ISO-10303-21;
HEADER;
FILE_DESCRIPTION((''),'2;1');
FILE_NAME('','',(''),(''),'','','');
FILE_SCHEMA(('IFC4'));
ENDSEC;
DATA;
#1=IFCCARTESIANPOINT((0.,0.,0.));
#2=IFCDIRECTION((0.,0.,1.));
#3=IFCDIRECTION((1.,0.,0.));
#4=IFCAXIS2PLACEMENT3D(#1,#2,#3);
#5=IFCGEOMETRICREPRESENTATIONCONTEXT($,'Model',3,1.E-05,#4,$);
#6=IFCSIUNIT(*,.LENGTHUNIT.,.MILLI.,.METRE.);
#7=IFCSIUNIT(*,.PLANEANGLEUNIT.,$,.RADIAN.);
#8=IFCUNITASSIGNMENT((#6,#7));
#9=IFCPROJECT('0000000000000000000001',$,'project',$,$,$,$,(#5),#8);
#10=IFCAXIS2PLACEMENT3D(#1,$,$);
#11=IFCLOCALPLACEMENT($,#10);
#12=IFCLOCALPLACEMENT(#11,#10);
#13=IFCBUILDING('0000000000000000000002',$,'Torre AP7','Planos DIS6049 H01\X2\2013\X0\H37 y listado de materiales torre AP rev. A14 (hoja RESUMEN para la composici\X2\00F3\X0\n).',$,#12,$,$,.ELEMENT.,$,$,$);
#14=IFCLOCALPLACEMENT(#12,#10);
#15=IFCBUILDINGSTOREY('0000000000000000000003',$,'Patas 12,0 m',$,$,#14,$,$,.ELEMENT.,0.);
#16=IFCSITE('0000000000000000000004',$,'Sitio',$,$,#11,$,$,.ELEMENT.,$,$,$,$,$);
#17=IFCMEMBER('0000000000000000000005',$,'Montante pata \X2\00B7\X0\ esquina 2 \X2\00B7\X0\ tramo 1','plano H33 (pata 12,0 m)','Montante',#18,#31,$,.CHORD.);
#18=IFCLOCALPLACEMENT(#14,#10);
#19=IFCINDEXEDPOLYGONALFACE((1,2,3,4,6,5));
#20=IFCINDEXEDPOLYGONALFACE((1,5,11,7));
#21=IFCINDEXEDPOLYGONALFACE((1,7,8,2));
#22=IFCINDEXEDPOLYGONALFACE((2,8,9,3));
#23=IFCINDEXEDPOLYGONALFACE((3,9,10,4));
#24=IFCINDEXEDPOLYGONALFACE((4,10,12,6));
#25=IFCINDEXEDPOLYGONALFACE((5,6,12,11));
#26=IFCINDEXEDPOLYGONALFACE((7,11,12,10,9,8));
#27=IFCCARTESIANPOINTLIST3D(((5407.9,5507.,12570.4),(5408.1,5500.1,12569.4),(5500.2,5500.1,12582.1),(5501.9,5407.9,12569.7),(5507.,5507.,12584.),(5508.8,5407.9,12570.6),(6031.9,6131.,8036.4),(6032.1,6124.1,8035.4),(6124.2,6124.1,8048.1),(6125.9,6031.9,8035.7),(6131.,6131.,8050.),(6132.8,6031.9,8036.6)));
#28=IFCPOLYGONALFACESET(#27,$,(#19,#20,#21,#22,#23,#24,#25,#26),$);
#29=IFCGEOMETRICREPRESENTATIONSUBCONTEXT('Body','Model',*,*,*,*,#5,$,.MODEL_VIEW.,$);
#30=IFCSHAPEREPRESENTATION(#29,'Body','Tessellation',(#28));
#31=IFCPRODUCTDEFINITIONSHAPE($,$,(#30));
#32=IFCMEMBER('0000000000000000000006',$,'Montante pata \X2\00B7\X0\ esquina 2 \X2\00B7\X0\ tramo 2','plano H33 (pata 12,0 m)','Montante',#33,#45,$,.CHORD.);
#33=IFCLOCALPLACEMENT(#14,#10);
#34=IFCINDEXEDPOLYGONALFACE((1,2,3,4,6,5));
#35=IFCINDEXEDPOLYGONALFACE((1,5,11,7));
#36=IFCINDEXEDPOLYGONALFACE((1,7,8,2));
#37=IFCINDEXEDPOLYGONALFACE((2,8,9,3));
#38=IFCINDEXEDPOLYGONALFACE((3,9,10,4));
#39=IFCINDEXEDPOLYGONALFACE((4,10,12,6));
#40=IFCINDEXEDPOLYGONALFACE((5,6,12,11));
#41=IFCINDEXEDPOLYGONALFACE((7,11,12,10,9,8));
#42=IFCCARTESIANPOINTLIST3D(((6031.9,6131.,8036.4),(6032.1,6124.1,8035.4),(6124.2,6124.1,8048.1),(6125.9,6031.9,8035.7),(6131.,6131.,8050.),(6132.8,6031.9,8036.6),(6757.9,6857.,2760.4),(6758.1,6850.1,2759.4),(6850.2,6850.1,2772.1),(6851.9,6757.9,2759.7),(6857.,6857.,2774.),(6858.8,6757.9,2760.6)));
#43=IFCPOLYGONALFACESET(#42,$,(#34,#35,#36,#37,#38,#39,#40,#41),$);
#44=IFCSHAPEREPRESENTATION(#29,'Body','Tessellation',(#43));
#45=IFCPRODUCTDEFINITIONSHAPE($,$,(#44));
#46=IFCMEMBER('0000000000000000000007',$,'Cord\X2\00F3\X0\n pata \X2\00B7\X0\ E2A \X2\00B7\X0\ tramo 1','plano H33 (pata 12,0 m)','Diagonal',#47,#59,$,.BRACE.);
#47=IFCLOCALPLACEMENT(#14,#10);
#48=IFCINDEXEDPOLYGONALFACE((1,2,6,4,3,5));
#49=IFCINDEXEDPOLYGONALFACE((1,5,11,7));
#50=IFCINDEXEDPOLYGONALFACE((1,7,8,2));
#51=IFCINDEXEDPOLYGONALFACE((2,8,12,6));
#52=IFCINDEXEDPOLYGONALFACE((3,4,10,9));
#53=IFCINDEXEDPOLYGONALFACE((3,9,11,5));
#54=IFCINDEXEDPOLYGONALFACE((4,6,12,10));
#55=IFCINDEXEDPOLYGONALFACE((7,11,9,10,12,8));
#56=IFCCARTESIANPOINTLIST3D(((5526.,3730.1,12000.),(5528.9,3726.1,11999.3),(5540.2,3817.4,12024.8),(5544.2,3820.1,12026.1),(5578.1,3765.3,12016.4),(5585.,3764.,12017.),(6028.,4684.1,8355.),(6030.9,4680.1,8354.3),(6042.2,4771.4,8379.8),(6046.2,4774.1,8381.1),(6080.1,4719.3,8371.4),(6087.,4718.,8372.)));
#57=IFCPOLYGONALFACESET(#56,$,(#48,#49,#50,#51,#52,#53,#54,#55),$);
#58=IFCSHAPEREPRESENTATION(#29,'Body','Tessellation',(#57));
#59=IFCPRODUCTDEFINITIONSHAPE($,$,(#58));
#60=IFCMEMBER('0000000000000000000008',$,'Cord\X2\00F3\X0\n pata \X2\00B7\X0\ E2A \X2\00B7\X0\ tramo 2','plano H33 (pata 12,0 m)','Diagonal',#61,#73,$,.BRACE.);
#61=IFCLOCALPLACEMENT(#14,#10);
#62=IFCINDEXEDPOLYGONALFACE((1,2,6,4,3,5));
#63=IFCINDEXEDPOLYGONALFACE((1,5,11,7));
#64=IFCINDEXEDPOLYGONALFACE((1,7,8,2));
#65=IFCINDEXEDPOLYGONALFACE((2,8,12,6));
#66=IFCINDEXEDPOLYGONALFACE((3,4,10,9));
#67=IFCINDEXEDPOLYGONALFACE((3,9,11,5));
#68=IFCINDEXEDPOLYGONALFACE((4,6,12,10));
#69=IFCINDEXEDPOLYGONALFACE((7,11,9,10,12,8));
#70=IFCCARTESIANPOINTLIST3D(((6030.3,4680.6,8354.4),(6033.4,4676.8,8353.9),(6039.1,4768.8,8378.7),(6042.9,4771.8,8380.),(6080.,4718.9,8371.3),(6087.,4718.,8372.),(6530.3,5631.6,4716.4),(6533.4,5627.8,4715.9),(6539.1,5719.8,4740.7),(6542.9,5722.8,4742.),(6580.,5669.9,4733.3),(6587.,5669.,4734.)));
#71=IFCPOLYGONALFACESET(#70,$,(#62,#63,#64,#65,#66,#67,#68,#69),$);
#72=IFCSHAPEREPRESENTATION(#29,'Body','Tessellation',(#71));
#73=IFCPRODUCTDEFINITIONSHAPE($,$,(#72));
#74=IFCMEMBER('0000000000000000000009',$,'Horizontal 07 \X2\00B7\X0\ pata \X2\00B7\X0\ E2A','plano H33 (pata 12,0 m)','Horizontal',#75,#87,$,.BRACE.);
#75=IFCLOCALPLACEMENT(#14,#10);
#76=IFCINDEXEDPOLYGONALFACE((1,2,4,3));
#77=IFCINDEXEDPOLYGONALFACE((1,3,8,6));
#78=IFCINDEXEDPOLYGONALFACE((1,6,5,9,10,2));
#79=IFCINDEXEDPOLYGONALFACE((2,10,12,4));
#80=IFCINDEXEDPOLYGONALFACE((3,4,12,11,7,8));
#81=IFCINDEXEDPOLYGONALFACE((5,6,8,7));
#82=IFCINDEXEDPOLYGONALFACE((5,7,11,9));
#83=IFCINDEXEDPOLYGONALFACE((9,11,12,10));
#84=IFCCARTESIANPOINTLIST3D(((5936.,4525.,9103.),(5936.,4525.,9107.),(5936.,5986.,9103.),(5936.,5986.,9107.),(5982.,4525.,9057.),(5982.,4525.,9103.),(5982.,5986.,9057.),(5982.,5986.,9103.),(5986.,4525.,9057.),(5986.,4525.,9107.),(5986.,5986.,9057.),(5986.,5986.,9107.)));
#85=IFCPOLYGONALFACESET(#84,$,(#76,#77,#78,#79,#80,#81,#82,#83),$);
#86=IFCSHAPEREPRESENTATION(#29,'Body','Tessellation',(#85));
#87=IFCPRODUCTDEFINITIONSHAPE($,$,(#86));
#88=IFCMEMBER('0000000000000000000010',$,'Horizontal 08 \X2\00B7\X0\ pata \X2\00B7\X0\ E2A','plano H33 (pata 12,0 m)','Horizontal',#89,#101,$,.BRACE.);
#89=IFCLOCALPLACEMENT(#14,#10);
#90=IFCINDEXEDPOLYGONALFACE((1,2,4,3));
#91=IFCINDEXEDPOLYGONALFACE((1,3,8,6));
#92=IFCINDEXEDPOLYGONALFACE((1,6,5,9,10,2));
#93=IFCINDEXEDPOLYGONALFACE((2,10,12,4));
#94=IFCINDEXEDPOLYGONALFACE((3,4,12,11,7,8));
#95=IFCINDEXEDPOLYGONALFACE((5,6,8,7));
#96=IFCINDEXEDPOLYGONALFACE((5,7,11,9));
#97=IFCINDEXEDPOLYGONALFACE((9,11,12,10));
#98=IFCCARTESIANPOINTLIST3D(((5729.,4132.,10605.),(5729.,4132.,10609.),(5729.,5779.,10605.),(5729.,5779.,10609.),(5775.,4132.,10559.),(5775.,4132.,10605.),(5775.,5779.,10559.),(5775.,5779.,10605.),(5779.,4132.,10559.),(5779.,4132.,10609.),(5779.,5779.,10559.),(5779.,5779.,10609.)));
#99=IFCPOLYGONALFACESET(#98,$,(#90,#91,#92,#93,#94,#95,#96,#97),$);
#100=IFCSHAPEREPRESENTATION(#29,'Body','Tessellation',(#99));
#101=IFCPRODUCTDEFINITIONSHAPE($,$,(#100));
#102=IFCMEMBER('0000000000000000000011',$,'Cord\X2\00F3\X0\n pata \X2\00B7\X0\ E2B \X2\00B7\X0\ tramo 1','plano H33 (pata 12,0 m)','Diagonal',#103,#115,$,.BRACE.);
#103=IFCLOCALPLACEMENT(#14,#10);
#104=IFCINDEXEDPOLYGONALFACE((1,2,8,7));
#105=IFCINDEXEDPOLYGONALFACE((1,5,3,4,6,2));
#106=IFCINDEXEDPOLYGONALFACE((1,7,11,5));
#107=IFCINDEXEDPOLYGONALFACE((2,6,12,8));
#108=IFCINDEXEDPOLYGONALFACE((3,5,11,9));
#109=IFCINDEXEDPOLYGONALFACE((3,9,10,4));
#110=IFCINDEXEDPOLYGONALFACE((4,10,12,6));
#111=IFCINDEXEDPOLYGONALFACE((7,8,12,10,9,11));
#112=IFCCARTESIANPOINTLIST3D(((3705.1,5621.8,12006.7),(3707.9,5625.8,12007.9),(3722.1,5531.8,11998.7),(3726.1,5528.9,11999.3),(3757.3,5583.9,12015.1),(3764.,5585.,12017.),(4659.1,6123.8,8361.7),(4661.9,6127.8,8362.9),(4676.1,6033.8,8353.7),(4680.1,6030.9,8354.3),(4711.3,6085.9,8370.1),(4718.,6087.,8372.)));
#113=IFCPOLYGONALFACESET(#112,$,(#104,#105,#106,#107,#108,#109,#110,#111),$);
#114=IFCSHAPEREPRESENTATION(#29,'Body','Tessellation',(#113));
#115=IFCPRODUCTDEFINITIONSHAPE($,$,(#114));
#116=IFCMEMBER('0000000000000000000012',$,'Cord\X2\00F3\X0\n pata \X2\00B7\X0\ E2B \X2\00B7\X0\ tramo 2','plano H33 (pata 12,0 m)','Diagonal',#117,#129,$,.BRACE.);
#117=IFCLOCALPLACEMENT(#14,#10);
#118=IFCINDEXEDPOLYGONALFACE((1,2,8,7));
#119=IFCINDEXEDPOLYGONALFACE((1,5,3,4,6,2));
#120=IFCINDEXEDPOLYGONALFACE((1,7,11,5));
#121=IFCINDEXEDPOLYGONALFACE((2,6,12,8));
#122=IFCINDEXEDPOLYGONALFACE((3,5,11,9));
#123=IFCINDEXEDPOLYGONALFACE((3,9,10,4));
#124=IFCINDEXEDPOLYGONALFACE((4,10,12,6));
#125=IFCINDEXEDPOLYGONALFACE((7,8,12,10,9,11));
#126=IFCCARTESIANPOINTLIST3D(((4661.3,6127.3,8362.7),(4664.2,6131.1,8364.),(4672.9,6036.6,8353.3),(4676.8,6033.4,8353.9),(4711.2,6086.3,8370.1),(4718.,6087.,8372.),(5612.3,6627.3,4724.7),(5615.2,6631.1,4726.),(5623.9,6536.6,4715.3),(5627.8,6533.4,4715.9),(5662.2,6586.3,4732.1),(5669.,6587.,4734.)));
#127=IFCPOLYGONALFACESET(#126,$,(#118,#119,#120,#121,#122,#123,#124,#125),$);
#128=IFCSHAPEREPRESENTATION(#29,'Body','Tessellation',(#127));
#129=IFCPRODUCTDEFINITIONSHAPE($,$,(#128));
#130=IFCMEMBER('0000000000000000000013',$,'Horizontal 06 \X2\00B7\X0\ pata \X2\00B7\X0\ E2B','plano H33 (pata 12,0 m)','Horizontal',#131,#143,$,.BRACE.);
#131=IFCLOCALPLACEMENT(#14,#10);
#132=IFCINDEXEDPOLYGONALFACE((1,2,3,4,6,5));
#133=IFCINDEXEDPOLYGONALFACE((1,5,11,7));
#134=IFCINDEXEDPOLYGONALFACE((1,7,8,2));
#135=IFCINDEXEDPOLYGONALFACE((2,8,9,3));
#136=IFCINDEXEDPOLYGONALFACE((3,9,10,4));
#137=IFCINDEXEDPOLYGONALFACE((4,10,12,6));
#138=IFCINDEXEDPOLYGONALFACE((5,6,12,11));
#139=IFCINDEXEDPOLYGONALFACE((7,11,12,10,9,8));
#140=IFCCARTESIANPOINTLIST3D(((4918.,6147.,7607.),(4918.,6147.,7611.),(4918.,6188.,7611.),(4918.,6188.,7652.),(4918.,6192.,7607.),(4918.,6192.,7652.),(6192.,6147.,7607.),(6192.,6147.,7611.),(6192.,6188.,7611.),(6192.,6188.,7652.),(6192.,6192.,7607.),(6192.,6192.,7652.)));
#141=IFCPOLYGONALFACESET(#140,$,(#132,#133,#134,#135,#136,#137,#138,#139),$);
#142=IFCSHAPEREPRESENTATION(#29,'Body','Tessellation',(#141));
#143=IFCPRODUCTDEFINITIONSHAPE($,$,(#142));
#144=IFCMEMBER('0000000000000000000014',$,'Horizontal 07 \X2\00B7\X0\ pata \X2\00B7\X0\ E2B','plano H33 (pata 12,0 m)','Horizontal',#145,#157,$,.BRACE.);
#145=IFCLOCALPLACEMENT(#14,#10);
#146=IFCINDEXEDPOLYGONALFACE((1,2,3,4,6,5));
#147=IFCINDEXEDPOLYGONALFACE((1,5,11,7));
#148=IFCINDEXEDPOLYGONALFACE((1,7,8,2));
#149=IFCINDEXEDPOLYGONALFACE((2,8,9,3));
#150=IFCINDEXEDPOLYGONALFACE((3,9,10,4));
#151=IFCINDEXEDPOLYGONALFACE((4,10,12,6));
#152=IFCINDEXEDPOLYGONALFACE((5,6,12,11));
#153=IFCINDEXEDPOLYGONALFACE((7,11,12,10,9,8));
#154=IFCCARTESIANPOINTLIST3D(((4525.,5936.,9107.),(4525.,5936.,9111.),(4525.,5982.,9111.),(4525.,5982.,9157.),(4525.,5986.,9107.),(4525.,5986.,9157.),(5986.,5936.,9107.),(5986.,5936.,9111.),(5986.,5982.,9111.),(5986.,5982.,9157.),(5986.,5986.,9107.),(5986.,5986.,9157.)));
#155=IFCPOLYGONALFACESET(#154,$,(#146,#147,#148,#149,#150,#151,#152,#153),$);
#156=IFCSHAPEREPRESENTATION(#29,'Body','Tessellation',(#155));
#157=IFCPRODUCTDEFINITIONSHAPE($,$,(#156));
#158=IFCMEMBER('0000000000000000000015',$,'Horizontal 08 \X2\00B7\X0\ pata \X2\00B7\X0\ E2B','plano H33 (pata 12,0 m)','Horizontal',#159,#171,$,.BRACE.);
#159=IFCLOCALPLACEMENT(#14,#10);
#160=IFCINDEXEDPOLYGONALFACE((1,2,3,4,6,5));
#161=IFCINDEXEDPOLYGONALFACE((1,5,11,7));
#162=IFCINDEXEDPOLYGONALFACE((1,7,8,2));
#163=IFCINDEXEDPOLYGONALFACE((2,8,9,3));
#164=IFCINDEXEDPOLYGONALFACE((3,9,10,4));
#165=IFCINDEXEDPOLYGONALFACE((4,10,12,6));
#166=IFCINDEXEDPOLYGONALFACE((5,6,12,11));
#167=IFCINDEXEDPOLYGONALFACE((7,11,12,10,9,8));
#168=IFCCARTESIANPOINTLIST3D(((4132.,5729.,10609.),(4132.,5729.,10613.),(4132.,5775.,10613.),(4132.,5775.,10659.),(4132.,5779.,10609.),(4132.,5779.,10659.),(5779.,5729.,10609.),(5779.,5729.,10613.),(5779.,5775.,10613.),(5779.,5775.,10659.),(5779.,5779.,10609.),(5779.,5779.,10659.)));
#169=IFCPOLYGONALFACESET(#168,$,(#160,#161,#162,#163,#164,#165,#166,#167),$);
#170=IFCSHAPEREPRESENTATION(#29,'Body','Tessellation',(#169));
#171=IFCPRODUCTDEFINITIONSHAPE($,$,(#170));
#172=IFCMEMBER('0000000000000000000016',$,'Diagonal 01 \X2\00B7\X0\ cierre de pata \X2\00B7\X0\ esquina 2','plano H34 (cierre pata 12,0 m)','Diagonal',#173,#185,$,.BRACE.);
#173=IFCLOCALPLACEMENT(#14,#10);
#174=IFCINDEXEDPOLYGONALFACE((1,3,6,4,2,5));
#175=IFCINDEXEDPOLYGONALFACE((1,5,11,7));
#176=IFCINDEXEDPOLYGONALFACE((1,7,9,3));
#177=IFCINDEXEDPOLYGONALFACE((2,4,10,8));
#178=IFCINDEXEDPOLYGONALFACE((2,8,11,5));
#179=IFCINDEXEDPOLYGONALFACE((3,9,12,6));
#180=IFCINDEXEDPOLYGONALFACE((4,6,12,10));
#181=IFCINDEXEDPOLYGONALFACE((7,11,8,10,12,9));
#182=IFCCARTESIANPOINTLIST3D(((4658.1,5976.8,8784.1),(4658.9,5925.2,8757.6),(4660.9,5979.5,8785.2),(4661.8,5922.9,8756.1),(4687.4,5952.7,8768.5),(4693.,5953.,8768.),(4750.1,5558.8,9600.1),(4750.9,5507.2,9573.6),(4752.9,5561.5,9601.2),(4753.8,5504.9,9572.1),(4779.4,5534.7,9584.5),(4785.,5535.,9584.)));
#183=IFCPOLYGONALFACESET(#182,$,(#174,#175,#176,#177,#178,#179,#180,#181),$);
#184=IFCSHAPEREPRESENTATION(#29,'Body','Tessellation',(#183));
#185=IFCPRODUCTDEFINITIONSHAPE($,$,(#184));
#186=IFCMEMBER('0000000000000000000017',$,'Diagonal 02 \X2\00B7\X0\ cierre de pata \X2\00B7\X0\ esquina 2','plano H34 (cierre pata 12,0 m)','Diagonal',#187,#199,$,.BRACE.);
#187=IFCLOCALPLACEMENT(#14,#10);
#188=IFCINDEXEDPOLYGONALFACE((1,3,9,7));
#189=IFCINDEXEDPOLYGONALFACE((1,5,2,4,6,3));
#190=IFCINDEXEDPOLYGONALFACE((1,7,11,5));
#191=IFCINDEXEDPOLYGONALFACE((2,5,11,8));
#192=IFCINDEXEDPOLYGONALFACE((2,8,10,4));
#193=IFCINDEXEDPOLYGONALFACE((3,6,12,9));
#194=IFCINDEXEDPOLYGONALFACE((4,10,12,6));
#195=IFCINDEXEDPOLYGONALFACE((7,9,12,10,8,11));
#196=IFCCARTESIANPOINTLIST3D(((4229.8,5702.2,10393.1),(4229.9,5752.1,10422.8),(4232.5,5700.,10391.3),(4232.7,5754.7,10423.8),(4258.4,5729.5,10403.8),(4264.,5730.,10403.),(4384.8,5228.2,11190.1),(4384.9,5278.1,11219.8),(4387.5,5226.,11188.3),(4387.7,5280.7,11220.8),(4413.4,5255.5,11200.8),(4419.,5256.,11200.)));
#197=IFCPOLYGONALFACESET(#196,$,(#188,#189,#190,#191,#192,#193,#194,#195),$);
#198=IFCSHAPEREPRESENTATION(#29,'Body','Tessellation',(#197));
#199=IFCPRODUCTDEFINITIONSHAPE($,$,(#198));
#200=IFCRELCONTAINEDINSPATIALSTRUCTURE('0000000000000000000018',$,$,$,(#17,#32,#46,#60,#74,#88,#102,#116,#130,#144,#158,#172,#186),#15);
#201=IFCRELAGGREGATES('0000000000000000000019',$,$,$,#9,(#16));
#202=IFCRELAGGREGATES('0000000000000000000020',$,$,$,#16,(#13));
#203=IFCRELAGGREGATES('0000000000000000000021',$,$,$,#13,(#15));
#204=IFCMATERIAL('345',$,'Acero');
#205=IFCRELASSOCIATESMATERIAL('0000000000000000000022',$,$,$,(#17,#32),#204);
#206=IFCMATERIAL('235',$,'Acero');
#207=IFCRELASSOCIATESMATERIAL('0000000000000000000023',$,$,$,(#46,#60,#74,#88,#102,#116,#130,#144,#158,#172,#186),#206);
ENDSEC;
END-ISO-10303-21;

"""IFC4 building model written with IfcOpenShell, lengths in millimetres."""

from ifc_helpers import new_model, si_unit, frame, frame_2d, origin, origin_with_axes, place, context, subcontext, project, spatial, l_section, extrude, material, element, save


model = new_model("IFC4")

# Units and contexts
model_context = context("Model", 3, precision=1e-05, world=origin_with_axes())
body_context = subcontext(model_context, "Body", "Model", "MODEL_VIEW")
ifc_project = project(units=[si_unit("LENGTHUNIT", "METRE", prefix="MILLI"), si_unit("PLANEANGLEUNIT", "RADIAN")], contexts=[model_context])

# Site, building, storey
site_placement = place(None, origin())
site = spatial("IfcSite", under=ifc_project, at=site_placement, Name="Sitio", CompositionType="ELEMENT")
building_placement = place(site_placement, origin())
building = spatial("IfcBuilding", under=site, at=building_placement, Name="Torre AP7", Description="Planos DIS6049 H01–H37 y listado de materiales torre AP rev. A14 (hoja RESUMEN para la composición).", CompositionType="ELEMENT")
storey_placement = place(building_placement, origin())
storey = spatial("IfcBuildingStorey", under=building, at=storey_placement, Name="Patas 12,0 m", CompositionType="ELEMENT", Elevation=0.0)

# Members
ifc_material_1 = material(Name="345", Category="Acero")
member_1_placement = place(storey_placement, frame((5507.0, 5507.0, 12584.0), z_axis=(0.135092, 0.135092, -0.981581), x_axis=(0.018419, -0.990833, -0.13383)))
element("IfcMember", 1, at=member_1_placement, inside=storey, material=ifc_material_1, Name="Montante pata · esquina 2 · tramo 1", Description="plano H33 (pata 12,0 m)", ObjectType="Montante", PredefinedType="CHORD", context=body_context, shape_type="SweptSolid", body=[
    extrude(l_section(Depth=100.0, Width=100.0, Thickness=7.0, at=frame_2d((50.0, 50.0))), None, (0.0, 0.0, 1.0), 4619.1),
])
member_2_placement = place(storey_placement, frame((6131.0, 6131.0, 8050.0), z_axis=(0.13507, 0.13507, -0.981586), x_axis=(0.018413, -0.990836, -0.13381)))
element("IfcMember", 2, at=member_2_placement, inside=storey, material=ifc_material_1, Name="Montante pata · esquina 2 · tramo 2", Description="plano H33 (pata 12,0 m)", ObjectType="Montante", PredefinedType="CHORD", context=body_context, shape_type="SweptSolid", body=[
    extrude(l_section(Depth=100.0, Width=100.0, Thickness=7.0, at=frame_2d((50.0, 50.0))), None, (0.0, 0.0, 1.0), 5375.0),
])
ifc_material_2 = material(Name="235", Category="Acero")
member_3_placement = place(storey_placement, frame((5585.0, 3764.0, 12017.0), z_axis=(0.132068, 0.250982, -0.95894), x_axis=(-0.801736, -0.541846, -0.252234)))
element("IfcMember", 3, at=member_3_placement, inside=storey, material=ifc_material_2, Name="Cordón pata · E2A · tramo 1", Description="plano H33 (pata 12,0 m)", ObjectType="Diagonal", PredefinedType="BRACE", context=body_context, shape_type="SweptSolid", body=[
    extrude(l_section(Depth=70.0, Width=70.0, Thickness=5.0, at=frame_2d((35.0, 35.0))), None, (0.0, 0.0, 1.0), 3801.1),
])
member_4_placement = place(storey_placement, frame((6087.0, 4718.0, 8372.0), z_axis=(0.13181, 0.250702, -0.959049), x_axis=(-0.76556, -0.588862, -0.25915)))
element("IfcMember", 4, at=member_4_placement, inside=storey, material=ifc_material_2, Name="Cordón pata · E2A · tramo 2", Description="plano H33 (pata 12,0 m)", ObjectType="Diagonal", PredefinedType="BRACE", context=body_context, shape_type="SweptSolid", body=[
    extrude(l_section(Depth=70.0, Width=70.0, Thickness=5.0, at=frame_2d((35.0, 35.0))), None, (0.0, 0.0, 1.0), 3793.3),
])
member_5_placement = place(storey_placement, frame((5986.0, 5986.0, 9107.0), z_axis=(0.0, -1.0, 0.0), x_axis=(-1.0, 0.0, 0.0)))
element("IfcMember", 5, at=member_5_placement, inside=storey, material=ifc_material_2, Name="Horizontal 07 · pata · E2A", Description="plano H33 (pata 12,0 m)", ObjectType="Horizontal", PredefinedType="BRACE", context=body_context, shape_type="SweptSolid", body=[
    extrude(l_section(Depth=50.0, Width=50.0, Thickness=4.0, at=frame_2d((25.0, 25.0))), None, (0.0, 0.0, 1.0), 1461.0),
])
member_6_placement = place(storey_placement, frame((5779.0, 5779.0, 10609.0), z_axis=(0.0, -1.0, 0.0), x_axis=(-1.0, 0.0, 0.0)))
element("IfcMember", 6, at=member_6_placement, inside=storey, material=ifc_material_2, Name="Horizontal 08 · pata · E2A", Description="plano H33 (pata 12,0 m)", ObjectType="Horizontal", PredefinedType="BRACE", context=body_context, shape_type="SweptSolid", body=[
    extrude(l_section(Depth=50.0, Width=50.0, Thickness=4.0, at=frame_2d((25.0, 25.0))), None, (0.0, 0.0, 1.0), 1647.0),
])
member_7_placement = place(storey_placement, frame((3764.0, 5585.0, 12017.0), z_axis=(0.250982, 0.132068, -0.95894), x_axis=(-0.541846, -0.801736, -0.252234)))
element("IfcMember", 7, at=member_7_placement, inside=storey, material=ifc_material_2, Name="Cordón pata · E2B · tramo 1", Description="plano H33 (pata 12,0 m)", ObjectType="Diagonal", PredefinedType="BRACE", context=body_context, shape_type="SweptSolid", body=[
    extrude(l_section(Depth=70.0, Width=70.0, Thickness=5.0, at=frame_2d((35.0, 35.0))), None, (0.0, 0.0, 1.0), 3801.1),
])
member_8_placement = place(storey_placement, frame((4718.0, 6087.0, 8372.0), z_axis=(0.250702, 0.13181, -0.959049), x_axis=(-0.588862, -0.76556, -0.25915)))
element("IfcMember", 8, at=member_8_placement, inside=storey, material=ifc_material_2, Name="Cordón pata · E2B · tramo 2", Description="plano H33 (pata 12,0 m)", ObjectType="Diagonal", PredefinedType="BRACE", context=body_context, shape_type="SweptSolid", body=[
    extrude(l_section(Depth=70.0, Width=70.0, Thickness=5.0, at=frame_2d((35.0, 35.0))), None, (0.0, 0.0, 1.0), 3793.3),
])
member_9_placement = place(storey_placement, frame((6192.0, 6192.0, 7607.0), z_axis=(-1.0, 0.0, 0.0), x_axis=(0.0, -1.0, 0.0)))
element("IfcMember", 9, at=member_9_placement, inside=storey, material=ifc_material_2, Name="Horizontal 06 · pata · E2B", Description="plano H33 (pata 12,0 m)", ObjectType="Horizontal", PredefinedType="BRACE", context=body_context, shape_type="SweptSolid", body=[
    extrude(l_section(Depth=45.0, Width=45.0, Thickness=4.0, at=frame_2d((22.5, 22.5))), None, (0.0, 0.0, 1.0), 1274.0),
])
member_10_placement = place(storey_placement, frame((5986.0, 5986.0, 9107.0), z_axis=(-1.0, 0.0, 0.0), x_axis=(0.0, -1.0, 0.0)))
element("IfcMember", 10, at=member_10_placement, inside=storey, material=ifc_material_2, Name="Horizontal 07 · pata · E2B", Description="plano H33 (pata 12,0 m)", ObjectType="Horizontal", PredefinedType="BRACE", context=body_context, shape_type="SweptSolid", body=[
    extrude(l_section(Depth=50.0, Width=50.0, Thickness=4.0, at=frame_2d((25.0, 25.0))), None, (0.0, 0.0, 1.0), 1461.0),
])
member_11_placement = place(storey_placement, frame((5779.0, 5779.0, 10609.0), z_axis=(-1.0, 0.0, 0.0), x_axis=(0.0, -1.0, 0.0)))
element("IfcMember", 11, at=member_11_placement, inside=storey, material=ifc_material_2, Name="Horizontal 08 · pata · E2B", Description="plano H33 (pata 12,0 m)", ObjectType="Horizontal", PredefinedType="BRACE", context=body_context, shape_type="SweptSolid", body=[
    extrude(l_section(Depth=50.0, Width=50.0, Thickness=4.0, at=frame_2d((25.0, 25.0))), None, (0.0, 0.0, 1.0), 1647.0),
])
member_12_placement = place(storey_placement, frame((4785.0, 5535.0, 9584.0), z_axis=(-0.099844, 0.45364, -0.885574), x_axis=(-0.694062, -0.669488, -0.264696)))
element("IfcMember", 12, at=member_12_placement, inside=storey, material=ifc_material_2, Name="Diagonal 01 · cierre de pata · esquina 2", Description="plano H34 (cierre pata 12,0 m)", ObjectType="Diagonal", PredefinedType="BRACE", context=body_context, shape_type="SweptSolid", body=[
    extrude(l_section(Depth=45.0, Width=45.0, Thickness=4.0, at=frame_2d((22.5, 22.5))), None, (0.0, 0.0, 1.0), 921.4),
])
member_13_placement = place(storey_placement, frame((4419.0, 5256.0, 11200.0), z_axis=(-0.164865, 0.504167, -0.847724), x_axis=(-0.699186, -0.665954, -0.260086)))
element("IfcMember", 13, at=member_13_placement, inside=storey, material=ifc_material_2, Name="Diagonal 02 · cierre de pata · esquina 2", Description="plano H34 (cierre pata 12,0 m)", ObjectType="Diagonal", PredefinedType="BRACE", context=body_context, shape_type="SweptSolid", body=[
    extrude(l_section(Depth=45.0, Width=45.0, Thickness=4.0, at=frame_2d((22.5, 22.5))), None, (0.0, 0.0, 1.0), 940.2),
])

save(model, "model.ifc")
